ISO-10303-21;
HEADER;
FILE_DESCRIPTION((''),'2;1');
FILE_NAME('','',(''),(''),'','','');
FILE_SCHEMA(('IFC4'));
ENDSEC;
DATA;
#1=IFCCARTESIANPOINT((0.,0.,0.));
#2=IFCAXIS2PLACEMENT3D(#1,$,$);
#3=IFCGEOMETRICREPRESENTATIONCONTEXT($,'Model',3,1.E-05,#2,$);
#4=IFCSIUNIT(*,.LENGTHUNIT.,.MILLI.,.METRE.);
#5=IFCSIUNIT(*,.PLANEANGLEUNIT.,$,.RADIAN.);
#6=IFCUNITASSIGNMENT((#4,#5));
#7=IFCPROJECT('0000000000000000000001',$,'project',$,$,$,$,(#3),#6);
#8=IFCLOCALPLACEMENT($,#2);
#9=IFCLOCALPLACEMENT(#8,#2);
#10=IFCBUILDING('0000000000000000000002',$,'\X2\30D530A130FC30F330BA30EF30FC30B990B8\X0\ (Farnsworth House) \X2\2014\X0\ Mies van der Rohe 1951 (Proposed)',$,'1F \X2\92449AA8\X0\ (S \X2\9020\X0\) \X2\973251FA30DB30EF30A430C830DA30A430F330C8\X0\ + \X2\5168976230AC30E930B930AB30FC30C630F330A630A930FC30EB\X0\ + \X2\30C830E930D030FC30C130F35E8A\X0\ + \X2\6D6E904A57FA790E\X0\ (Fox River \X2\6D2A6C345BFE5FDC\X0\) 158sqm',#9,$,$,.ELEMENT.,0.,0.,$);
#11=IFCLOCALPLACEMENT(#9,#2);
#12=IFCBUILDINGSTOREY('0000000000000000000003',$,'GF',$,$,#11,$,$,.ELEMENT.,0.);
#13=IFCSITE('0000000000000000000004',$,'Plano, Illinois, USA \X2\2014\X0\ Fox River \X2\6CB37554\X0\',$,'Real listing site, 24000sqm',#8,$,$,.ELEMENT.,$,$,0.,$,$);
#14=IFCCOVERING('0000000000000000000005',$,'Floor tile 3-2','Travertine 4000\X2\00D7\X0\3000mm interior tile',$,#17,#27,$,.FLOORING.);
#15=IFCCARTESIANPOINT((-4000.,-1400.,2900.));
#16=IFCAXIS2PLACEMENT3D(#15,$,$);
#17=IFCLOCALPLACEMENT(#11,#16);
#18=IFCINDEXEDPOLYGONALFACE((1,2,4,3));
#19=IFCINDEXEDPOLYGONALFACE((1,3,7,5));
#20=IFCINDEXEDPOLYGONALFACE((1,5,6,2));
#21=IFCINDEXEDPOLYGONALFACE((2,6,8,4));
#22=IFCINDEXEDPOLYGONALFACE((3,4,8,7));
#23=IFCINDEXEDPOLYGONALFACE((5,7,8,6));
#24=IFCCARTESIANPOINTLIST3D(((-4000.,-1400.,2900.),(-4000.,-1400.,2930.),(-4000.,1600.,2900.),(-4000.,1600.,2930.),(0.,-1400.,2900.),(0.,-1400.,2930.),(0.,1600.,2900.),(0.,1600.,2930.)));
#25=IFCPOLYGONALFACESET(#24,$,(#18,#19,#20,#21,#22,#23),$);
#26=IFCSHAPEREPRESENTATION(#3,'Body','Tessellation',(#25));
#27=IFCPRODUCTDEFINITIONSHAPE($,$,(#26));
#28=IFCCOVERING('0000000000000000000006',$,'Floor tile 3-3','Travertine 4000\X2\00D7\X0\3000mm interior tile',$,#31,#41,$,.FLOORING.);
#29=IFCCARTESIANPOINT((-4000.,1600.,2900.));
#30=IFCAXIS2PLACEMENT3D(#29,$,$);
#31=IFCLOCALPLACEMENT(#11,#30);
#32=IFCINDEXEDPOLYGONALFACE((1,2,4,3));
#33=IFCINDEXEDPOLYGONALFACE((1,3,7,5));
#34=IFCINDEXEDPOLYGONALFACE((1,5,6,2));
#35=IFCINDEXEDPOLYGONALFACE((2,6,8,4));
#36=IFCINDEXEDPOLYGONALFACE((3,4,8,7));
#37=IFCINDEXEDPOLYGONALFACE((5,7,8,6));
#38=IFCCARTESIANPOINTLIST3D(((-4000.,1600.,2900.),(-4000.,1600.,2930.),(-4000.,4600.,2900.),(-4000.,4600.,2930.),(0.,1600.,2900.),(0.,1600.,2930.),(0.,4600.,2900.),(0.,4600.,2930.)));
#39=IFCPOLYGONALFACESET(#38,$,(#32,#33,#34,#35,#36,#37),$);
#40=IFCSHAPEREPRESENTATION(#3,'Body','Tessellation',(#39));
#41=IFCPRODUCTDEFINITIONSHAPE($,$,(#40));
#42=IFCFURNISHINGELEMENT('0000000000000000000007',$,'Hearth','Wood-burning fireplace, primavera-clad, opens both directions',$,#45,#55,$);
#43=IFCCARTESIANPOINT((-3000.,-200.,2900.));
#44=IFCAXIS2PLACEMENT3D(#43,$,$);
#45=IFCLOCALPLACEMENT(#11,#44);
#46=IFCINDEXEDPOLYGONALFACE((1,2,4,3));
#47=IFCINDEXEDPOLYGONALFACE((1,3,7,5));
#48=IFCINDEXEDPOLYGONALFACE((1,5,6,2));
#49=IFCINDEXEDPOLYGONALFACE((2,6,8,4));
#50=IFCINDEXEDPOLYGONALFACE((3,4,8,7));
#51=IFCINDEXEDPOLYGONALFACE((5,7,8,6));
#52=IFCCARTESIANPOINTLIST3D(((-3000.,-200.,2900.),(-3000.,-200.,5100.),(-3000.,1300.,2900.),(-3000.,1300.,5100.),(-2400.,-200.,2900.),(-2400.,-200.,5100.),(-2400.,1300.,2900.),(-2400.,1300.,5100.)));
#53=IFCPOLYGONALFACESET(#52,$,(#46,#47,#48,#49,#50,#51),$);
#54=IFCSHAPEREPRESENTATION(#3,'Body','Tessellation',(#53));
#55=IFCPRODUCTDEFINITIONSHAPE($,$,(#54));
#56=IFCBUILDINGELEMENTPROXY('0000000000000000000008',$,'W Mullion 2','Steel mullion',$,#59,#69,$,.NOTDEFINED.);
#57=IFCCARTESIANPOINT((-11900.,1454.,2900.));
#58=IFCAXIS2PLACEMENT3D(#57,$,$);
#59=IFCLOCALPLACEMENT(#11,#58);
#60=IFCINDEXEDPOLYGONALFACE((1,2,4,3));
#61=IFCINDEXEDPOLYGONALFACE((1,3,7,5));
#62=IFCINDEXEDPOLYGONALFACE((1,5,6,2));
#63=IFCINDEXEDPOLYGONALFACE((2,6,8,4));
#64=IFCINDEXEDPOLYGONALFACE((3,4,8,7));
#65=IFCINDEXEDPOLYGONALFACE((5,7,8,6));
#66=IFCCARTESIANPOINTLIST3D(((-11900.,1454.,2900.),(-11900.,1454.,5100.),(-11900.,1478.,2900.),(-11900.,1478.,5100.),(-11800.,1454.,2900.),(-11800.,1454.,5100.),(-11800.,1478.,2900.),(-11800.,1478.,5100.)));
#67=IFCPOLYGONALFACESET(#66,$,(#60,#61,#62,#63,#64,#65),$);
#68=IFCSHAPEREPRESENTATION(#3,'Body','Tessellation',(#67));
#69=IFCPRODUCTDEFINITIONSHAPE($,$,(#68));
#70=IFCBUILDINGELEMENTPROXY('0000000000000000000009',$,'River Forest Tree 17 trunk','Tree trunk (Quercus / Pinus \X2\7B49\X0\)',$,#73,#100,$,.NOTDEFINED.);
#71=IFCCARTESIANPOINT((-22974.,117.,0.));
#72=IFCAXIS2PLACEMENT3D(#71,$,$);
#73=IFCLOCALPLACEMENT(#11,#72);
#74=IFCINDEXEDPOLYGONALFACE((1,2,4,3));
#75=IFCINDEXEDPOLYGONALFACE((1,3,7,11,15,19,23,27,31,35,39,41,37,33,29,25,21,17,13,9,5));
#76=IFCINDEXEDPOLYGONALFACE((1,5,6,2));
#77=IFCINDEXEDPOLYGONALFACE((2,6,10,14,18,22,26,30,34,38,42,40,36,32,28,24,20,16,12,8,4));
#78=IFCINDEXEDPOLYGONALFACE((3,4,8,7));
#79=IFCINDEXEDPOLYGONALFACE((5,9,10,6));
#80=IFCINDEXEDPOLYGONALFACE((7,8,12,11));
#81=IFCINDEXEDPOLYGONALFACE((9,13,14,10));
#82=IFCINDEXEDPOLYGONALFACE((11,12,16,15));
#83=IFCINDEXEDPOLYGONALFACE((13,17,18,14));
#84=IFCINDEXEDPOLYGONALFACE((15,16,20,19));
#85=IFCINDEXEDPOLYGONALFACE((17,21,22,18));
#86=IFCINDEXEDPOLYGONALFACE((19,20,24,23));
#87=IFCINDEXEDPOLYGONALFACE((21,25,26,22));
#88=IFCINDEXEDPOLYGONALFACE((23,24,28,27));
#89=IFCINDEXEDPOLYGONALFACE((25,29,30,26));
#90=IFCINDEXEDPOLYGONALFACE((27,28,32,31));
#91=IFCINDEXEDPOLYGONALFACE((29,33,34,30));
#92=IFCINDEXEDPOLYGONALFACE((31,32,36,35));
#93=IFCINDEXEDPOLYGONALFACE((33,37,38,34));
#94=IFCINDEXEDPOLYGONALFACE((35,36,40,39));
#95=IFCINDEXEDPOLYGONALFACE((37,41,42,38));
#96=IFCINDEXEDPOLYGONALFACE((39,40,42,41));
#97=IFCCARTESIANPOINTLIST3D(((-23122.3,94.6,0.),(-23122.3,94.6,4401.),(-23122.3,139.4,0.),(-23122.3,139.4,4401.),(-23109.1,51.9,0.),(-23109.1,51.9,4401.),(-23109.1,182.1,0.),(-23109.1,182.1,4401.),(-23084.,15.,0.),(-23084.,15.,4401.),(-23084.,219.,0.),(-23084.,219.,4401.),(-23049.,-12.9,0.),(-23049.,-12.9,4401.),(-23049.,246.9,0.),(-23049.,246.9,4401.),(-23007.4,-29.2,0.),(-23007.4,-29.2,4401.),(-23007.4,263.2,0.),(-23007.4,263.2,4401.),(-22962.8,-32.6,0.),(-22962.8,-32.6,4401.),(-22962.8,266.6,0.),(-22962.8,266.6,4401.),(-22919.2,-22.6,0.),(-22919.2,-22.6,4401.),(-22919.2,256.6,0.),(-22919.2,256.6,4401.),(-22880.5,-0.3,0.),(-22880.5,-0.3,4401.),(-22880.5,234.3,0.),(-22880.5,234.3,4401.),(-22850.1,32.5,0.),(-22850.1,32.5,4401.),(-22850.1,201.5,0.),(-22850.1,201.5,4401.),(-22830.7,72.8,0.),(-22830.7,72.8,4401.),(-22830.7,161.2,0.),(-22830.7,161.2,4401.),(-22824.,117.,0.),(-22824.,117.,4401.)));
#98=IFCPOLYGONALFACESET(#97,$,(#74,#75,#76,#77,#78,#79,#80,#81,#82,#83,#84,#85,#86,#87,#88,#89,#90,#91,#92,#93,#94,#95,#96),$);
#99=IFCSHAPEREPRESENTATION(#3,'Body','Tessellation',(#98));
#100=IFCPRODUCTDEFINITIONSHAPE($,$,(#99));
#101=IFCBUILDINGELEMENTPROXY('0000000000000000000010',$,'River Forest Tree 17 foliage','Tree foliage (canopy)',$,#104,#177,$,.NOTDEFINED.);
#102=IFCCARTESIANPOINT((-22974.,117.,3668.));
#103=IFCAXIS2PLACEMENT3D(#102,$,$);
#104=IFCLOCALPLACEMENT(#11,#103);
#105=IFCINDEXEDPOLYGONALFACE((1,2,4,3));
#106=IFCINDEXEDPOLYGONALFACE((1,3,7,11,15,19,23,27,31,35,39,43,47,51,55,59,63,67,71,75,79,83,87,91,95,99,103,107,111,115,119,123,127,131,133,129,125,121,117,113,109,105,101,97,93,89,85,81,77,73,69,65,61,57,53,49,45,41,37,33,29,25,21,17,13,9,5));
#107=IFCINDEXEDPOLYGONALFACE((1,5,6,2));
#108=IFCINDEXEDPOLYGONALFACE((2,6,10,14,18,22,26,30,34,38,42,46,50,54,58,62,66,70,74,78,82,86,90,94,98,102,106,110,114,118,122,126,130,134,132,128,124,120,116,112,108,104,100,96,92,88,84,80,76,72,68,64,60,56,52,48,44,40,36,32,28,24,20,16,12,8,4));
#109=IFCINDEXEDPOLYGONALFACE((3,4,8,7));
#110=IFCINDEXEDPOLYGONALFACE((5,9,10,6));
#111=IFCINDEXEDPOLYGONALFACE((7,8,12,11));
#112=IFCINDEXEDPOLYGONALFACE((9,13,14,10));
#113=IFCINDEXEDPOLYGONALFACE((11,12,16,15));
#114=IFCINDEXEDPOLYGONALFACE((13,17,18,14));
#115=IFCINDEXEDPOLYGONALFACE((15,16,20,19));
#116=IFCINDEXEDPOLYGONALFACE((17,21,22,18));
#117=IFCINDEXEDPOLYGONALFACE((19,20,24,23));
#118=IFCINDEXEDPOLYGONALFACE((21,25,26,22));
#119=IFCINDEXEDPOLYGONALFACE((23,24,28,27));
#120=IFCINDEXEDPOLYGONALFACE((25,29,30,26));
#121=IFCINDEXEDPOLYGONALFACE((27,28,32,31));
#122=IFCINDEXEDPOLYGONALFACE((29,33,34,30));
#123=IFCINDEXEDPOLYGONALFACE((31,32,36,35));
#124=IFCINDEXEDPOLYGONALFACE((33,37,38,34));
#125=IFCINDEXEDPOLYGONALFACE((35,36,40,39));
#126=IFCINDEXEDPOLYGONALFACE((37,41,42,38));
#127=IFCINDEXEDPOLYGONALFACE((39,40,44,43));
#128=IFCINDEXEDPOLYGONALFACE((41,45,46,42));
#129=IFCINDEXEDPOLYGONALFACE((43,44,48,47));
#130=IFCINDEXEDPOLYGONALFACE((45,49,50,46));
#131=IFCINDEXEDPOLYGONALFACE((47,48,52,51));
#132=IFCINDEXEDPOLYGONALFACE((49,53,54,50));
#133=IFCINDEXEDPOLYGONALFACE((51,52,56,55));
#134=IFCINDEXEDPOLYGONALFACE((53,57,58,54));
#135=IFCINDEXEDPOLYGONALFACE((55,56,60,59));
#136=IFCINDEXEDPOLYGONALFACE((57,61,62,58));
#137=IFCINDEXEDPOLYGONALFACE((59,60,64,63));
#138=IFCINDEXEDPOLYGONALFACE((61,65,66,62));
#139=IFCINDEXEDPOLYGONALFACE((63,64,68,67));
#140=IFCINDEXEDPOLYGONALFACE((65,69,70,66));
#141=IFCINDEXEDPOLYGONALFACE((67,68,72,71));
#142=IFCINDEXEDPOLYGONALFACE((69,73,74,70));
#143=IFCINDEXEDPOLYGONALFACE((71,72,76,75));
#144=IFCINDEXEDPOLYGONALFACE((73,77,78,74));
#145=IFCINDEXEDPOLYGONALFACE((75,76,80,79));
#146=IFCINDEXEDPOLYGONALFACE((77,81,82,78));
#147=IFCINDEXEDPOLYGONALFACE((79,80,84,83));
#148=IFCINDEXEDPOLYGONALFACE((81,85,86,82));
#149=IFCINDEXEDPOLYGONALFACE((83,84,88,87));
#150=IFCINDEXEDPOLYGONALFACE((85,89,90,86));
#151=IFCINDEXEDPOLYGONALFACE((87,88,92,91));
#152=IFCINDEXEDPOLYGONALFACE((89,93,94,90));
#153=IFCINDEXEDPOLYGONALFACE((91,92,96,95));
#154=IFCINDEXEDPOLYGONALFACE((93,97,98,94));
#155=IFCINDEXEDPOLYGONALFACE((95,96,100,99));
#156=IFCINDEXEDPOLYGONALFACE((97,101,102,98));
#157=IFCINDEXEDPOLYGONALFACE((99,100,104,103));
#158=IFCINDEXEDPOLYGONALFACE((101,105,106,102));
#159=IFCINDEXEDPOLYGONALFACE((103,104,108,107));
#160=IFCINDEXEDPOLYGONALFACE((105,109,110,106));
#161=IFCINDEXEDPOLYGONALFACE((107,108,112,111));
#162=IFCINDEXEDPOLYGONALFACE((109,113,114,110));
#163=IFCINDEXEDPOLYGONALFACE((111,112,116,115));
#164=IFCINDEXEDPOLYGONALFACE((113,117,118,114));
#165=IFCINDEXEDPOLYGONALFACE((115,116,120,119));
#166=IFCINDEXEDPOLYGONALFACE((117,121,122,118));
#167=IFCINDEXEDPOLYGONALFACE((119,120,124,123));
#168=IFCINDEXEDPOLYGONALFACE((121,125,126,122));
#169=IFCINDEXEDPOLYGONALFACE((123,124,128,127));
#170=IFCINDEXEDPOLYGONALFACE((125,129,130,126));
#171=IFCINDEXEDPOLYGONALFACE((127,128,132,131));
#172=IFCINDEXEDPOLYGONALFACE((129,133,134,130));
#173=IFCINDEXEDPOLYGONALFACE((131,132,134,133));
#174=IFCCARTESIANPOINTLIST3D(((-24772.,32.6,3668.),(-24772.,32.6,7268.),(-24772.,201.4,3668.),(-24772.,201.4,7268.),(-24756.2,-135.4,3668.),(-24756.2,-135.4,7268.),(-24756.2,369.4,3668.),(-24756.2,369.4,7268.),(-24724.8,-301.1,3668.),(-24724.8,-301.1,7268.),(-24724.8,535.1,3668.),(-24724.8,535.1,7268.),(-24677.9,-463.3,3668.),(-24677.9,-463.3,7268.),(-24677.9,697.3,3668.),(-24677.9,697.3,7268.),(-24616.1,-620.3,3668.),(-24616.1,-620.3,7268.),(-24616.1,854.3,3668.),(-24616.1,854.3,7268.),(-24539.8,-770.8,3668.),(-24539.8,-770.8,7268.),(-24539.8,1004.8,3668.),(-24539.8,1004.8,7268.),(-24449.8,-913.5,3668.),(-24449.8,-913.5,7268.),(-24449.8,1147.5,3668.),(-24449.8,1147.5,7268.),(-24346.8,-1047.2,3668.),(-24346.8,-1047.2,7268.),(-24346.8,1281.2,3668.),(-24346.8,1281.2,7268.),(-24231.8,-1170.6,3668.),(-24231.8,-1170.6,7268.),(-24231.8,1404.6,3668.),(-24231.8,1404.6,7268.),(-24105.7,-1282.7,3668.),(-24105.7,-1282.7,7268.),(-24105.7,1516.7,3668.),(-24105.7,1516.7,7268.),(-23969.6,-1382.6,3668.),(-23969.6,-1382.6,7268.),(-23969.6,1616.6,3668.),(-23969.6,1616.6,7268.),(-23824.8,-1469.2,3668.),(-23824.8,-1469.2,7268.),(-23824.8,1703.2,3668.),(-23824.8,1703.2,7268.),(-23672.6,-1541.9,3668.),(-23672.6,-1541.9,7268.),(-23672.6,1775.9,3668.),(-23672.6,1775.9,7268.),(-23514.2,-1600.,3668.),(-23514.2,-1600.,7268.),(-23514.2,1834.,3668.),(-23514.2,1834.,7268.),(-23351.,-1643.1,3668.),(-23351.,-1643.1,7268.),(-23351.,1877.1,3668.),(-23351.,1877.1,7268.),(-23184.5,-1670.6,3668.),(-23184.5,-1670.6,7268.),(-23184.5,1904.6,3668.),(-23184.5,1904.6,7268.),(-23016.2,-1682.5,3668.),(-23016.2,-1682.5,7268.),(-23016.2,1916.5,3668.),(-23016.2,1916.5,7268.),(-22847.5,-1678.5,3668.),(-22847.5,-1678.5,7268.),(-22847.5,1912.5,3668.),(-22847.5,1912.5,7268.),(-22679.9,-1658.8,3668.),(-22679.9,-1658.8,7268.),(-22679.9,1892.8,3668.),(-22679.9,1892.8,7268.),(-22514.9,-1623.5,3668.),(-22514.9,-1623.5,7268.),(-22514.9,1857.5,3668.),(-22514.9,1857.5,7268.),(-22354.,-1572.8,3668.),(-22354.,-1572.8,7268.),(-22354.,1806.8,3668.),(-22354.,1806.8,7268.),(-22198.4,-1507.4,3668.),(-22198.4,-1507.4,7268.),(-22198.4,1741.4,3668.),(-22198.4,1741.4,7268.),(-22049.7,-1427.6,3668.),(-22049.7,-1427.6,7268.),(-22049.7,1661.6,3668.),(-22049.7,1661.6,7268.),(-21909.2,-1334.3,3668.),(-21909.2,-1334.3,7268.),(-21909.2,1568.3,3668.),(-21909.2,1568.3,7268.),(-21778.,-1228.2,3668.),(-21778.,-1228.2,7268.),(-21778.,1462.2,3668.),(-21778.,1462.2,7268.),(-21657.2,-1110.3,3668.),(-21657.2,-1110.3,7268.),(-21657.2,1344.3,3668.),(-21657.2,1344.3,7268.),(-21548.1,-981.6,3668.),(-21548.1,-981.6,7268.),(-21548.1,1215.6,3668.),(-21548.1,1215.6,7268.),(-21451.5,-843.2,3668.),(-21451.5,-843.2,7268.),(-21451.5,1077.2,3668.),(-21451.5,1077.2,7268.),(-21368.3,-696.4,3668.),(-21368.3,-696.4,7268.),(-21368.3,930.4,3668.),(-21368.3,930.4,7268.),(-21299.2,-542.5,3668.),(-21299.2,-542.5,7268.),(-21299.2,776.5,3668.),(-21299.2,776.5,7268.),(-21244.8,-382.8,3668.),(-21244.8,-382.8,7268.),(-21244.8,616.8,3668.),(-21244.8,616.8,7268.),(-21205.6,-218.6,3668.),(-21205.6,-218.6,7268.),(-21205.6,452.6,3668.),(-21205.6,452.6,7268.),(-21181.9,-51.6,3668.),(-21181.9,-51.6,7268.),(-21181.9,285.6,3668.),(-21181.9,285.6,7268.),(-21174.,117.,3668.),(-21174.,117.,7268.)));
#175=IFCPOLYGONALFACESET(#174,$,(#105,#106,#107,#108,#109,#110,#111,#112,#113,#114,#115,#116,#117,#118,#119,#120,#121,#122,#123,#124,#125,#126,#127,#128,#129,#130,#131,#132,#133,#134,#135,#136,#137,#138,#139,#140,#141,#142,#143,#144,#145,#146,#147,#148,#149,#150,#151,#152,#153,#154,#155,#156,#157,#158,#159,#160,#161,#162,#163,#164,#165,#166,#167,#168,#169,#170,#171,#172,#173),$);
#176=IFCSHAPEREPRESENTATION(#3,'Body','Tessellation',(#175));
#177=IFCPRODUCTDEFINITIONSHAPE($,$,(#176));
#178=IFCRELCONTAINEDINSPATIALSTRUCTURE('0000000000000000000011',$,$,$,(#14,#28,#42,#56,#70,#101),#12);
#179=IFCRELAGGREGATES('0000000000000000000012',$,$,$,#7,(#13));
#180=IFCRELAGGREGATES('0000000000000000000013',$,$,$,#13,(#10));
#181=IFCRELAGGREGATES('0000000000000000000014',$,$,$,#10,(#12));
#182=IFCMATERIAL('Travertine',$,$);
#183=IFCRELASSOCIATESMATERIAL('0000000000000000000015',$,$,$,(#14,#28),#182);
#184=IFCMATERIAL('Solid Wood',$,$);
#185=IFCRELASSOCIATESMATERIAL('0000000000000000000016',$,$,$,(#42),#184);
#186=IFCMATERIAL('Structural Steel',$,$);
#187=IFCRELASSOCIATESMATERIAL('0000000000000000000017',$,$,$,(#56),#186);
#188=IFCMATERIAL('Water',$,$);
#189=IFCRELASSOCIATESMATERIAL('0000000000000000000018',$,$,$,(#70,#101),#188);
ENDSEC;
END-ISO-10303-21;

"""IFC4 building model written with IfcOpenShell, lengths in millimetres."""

from ifc_helpers import new_model, si_unit, frame, frame_2d, origin, origin_2d, place, context, project, spatial, rectangle, circle, extrude, material, element, save


model = new_model("IFC4")

# Units and contexts
model_context = context("Model", 3, precision=1e-05, world=origin())
ifc_project = project(units=[si_unit("LENGTHUNIT", "METRE", prefix="MILLI"), si_unit("PLANEANGLEUNIT", "RADIAN")], contexts=[model_context])

# Site, building, storey
site_placement = place(None, origin())
site = spatial("IfcSite", under=ifc_project, at=site_placement, Name="Plano, Illinois, USA — Fox River 河畔", ObjectType="Real listing site, 24000sqm", CompositionType="ELEMENT", RefElevation=0.0)
building_placement = place(site_placement, origin())
building = spatial("IfcBuilding", under=site, at=building_placement, Name="ファーンズワース邸 (Farnsworth House) — Mies van der Rohe 1951 (Proposed)", ObjectType="1F 鉄骨 (S 造) 露出ホワイトペイント + 全面ガラスカーテンウォール + トラバーチン床 + 浮遊基礎 (Fox River 洪水対応) 158sqm", CompositionType="ELEMENT", ElevationOfRefHeight=0.0, ElevationOfTerrain=0.0)
storey_placement = place(building_placement, origin())
storey = spatial("IfcBuildingStorey", under=building, at=storey_placement, Name="GF", CompositionType="ELEMENT", Elevation=0.0)

# Shared definitions
ifc_material_1 = material(Name="Structural Steel")

# Shared definitions
ifc_material_2 = material(Name="Solid Wood")

# Coverings
ifc_material_3 = material(Name="Travertine")
covering_1_placement = place(storey_placement, frame((-4000.0, -1400.0, 2900.0)))
element("IfcCovering", 1, at=covering_1_placement, inside=storey, material=ifc_material_3, Name="Floor tile 3-2", Description="Travertine 4000×3000mm interior tile", PredefinedType="FLOORING", context=model_context, shape_type="SweptSolid", body=[
    extrude(rectangle(XDim=4000.0, YDim=3000.0, at=frame_2d((2000.0, 1500.0))), frame((-4000.0, -1400.0, 2900.0)), (0.0, 0.0, 1.0), 30.0),
])
covering_2_placement = place(storey_placement, frame((-4000.0, 1600.0, 2900.0)))
element("IfcCovering", 2, at=covering_2_placement, inside=storey, material=ifc_material_3, Name="Floor tile 3-3", Description="Travertine 4000×3000mm interior tile", PredefinedType="FLOORING", context=model_context, shape_type="SweptSolid", body=[
    extrude(rectangle(XDim=4000.0, YDim=3000.0, at=frame_2d((2000.0, 1500.0))), frame((-4000.0, 1600.0, 2900.0)), (0.0, 0.0, 1.0), 30.0),
])

# Furnishing element
furnishing_placement = place(storey_placement, frame((-3000.0, -200.0, 2900.0)))
element("IfcFurnishingElement", 3, at=furnishing_placement, inside=storey, material=ifc_material_2, Name="Hearth", Description="Wood-burning fireplace, primavera-clad, opens both directions", context=model_context, shape_type="SweptSolid", body=[
    extrude(rectangle(XDim=600.0, YDim=1500.0, at=frame_2d((300.0, 750.0))), frame((-3000.0, -200.0, 2900.0)), (0.0, 0.0, 1.0), 2200.0),
])

# Building element proxies
proxy_1_placement = place(storey_placement, frame((-11900.0, 1454.0, 2900.0)))
element("IfcBuildingElementProxy", 4, at=proxy_1_placement, inside=storey, material=ifc_material_1, Name="W Mullion 2", Description="Steel mullion", PredefinedType="NOTDEFINED", context=model_context, shape_type="SweptSolid", body=[
    extrude(rectangle(XDim=100.0, YDim=24.0, at=frame_2d((50.0, 12.0))), frame((-11900.0, 1454.0, 2900.0)), (0.0, 0.0, 1.0), 2200.0),
])
ifc_material_4 = material(Name="Water")
proxy_2_placement = place(storey_placement, frame((-22974.0, 117.0, 0.0)))
element("IfcBuildingElementProxy", 5, at=proxy_2_placement, inside=storey, material=ifc_material_4, Name="River Forest Tree 17 trunk", Description="Tree trunk (Quercus / Pinus 等)", PredefinedType="NOTDEFINED", context=model_context, shape_type="SweptSolid", body=[
    extrude(circle(Radius=150.0, at=origin_2d()), frame((-22974.0, 117.0, 0.0)), (0.0, 0.0, 1.0), 4401.0),
])
proxy_3_placement = place(storey_placement, frame((-22974.0, 117.0, 3668.0)))
element("IfcBuildingElementProxy", 6, at=proxy_3_placement, inside=storey, material=ifc_material_4, Name="River Forest Tree 17 foliage", Description="Tree foliage (canopy)", PredefinedType="NOTDEFINED", context=model_context, shape_type="SweptSolid", body=[
    extrude(circle(Radius=1800.0, at=origin_2d()), frame((-22974.0, 117.0, 3668.0)), (0.0, 0.0, 1.0), 3600.0),
])

save(model, "model.ifc")
